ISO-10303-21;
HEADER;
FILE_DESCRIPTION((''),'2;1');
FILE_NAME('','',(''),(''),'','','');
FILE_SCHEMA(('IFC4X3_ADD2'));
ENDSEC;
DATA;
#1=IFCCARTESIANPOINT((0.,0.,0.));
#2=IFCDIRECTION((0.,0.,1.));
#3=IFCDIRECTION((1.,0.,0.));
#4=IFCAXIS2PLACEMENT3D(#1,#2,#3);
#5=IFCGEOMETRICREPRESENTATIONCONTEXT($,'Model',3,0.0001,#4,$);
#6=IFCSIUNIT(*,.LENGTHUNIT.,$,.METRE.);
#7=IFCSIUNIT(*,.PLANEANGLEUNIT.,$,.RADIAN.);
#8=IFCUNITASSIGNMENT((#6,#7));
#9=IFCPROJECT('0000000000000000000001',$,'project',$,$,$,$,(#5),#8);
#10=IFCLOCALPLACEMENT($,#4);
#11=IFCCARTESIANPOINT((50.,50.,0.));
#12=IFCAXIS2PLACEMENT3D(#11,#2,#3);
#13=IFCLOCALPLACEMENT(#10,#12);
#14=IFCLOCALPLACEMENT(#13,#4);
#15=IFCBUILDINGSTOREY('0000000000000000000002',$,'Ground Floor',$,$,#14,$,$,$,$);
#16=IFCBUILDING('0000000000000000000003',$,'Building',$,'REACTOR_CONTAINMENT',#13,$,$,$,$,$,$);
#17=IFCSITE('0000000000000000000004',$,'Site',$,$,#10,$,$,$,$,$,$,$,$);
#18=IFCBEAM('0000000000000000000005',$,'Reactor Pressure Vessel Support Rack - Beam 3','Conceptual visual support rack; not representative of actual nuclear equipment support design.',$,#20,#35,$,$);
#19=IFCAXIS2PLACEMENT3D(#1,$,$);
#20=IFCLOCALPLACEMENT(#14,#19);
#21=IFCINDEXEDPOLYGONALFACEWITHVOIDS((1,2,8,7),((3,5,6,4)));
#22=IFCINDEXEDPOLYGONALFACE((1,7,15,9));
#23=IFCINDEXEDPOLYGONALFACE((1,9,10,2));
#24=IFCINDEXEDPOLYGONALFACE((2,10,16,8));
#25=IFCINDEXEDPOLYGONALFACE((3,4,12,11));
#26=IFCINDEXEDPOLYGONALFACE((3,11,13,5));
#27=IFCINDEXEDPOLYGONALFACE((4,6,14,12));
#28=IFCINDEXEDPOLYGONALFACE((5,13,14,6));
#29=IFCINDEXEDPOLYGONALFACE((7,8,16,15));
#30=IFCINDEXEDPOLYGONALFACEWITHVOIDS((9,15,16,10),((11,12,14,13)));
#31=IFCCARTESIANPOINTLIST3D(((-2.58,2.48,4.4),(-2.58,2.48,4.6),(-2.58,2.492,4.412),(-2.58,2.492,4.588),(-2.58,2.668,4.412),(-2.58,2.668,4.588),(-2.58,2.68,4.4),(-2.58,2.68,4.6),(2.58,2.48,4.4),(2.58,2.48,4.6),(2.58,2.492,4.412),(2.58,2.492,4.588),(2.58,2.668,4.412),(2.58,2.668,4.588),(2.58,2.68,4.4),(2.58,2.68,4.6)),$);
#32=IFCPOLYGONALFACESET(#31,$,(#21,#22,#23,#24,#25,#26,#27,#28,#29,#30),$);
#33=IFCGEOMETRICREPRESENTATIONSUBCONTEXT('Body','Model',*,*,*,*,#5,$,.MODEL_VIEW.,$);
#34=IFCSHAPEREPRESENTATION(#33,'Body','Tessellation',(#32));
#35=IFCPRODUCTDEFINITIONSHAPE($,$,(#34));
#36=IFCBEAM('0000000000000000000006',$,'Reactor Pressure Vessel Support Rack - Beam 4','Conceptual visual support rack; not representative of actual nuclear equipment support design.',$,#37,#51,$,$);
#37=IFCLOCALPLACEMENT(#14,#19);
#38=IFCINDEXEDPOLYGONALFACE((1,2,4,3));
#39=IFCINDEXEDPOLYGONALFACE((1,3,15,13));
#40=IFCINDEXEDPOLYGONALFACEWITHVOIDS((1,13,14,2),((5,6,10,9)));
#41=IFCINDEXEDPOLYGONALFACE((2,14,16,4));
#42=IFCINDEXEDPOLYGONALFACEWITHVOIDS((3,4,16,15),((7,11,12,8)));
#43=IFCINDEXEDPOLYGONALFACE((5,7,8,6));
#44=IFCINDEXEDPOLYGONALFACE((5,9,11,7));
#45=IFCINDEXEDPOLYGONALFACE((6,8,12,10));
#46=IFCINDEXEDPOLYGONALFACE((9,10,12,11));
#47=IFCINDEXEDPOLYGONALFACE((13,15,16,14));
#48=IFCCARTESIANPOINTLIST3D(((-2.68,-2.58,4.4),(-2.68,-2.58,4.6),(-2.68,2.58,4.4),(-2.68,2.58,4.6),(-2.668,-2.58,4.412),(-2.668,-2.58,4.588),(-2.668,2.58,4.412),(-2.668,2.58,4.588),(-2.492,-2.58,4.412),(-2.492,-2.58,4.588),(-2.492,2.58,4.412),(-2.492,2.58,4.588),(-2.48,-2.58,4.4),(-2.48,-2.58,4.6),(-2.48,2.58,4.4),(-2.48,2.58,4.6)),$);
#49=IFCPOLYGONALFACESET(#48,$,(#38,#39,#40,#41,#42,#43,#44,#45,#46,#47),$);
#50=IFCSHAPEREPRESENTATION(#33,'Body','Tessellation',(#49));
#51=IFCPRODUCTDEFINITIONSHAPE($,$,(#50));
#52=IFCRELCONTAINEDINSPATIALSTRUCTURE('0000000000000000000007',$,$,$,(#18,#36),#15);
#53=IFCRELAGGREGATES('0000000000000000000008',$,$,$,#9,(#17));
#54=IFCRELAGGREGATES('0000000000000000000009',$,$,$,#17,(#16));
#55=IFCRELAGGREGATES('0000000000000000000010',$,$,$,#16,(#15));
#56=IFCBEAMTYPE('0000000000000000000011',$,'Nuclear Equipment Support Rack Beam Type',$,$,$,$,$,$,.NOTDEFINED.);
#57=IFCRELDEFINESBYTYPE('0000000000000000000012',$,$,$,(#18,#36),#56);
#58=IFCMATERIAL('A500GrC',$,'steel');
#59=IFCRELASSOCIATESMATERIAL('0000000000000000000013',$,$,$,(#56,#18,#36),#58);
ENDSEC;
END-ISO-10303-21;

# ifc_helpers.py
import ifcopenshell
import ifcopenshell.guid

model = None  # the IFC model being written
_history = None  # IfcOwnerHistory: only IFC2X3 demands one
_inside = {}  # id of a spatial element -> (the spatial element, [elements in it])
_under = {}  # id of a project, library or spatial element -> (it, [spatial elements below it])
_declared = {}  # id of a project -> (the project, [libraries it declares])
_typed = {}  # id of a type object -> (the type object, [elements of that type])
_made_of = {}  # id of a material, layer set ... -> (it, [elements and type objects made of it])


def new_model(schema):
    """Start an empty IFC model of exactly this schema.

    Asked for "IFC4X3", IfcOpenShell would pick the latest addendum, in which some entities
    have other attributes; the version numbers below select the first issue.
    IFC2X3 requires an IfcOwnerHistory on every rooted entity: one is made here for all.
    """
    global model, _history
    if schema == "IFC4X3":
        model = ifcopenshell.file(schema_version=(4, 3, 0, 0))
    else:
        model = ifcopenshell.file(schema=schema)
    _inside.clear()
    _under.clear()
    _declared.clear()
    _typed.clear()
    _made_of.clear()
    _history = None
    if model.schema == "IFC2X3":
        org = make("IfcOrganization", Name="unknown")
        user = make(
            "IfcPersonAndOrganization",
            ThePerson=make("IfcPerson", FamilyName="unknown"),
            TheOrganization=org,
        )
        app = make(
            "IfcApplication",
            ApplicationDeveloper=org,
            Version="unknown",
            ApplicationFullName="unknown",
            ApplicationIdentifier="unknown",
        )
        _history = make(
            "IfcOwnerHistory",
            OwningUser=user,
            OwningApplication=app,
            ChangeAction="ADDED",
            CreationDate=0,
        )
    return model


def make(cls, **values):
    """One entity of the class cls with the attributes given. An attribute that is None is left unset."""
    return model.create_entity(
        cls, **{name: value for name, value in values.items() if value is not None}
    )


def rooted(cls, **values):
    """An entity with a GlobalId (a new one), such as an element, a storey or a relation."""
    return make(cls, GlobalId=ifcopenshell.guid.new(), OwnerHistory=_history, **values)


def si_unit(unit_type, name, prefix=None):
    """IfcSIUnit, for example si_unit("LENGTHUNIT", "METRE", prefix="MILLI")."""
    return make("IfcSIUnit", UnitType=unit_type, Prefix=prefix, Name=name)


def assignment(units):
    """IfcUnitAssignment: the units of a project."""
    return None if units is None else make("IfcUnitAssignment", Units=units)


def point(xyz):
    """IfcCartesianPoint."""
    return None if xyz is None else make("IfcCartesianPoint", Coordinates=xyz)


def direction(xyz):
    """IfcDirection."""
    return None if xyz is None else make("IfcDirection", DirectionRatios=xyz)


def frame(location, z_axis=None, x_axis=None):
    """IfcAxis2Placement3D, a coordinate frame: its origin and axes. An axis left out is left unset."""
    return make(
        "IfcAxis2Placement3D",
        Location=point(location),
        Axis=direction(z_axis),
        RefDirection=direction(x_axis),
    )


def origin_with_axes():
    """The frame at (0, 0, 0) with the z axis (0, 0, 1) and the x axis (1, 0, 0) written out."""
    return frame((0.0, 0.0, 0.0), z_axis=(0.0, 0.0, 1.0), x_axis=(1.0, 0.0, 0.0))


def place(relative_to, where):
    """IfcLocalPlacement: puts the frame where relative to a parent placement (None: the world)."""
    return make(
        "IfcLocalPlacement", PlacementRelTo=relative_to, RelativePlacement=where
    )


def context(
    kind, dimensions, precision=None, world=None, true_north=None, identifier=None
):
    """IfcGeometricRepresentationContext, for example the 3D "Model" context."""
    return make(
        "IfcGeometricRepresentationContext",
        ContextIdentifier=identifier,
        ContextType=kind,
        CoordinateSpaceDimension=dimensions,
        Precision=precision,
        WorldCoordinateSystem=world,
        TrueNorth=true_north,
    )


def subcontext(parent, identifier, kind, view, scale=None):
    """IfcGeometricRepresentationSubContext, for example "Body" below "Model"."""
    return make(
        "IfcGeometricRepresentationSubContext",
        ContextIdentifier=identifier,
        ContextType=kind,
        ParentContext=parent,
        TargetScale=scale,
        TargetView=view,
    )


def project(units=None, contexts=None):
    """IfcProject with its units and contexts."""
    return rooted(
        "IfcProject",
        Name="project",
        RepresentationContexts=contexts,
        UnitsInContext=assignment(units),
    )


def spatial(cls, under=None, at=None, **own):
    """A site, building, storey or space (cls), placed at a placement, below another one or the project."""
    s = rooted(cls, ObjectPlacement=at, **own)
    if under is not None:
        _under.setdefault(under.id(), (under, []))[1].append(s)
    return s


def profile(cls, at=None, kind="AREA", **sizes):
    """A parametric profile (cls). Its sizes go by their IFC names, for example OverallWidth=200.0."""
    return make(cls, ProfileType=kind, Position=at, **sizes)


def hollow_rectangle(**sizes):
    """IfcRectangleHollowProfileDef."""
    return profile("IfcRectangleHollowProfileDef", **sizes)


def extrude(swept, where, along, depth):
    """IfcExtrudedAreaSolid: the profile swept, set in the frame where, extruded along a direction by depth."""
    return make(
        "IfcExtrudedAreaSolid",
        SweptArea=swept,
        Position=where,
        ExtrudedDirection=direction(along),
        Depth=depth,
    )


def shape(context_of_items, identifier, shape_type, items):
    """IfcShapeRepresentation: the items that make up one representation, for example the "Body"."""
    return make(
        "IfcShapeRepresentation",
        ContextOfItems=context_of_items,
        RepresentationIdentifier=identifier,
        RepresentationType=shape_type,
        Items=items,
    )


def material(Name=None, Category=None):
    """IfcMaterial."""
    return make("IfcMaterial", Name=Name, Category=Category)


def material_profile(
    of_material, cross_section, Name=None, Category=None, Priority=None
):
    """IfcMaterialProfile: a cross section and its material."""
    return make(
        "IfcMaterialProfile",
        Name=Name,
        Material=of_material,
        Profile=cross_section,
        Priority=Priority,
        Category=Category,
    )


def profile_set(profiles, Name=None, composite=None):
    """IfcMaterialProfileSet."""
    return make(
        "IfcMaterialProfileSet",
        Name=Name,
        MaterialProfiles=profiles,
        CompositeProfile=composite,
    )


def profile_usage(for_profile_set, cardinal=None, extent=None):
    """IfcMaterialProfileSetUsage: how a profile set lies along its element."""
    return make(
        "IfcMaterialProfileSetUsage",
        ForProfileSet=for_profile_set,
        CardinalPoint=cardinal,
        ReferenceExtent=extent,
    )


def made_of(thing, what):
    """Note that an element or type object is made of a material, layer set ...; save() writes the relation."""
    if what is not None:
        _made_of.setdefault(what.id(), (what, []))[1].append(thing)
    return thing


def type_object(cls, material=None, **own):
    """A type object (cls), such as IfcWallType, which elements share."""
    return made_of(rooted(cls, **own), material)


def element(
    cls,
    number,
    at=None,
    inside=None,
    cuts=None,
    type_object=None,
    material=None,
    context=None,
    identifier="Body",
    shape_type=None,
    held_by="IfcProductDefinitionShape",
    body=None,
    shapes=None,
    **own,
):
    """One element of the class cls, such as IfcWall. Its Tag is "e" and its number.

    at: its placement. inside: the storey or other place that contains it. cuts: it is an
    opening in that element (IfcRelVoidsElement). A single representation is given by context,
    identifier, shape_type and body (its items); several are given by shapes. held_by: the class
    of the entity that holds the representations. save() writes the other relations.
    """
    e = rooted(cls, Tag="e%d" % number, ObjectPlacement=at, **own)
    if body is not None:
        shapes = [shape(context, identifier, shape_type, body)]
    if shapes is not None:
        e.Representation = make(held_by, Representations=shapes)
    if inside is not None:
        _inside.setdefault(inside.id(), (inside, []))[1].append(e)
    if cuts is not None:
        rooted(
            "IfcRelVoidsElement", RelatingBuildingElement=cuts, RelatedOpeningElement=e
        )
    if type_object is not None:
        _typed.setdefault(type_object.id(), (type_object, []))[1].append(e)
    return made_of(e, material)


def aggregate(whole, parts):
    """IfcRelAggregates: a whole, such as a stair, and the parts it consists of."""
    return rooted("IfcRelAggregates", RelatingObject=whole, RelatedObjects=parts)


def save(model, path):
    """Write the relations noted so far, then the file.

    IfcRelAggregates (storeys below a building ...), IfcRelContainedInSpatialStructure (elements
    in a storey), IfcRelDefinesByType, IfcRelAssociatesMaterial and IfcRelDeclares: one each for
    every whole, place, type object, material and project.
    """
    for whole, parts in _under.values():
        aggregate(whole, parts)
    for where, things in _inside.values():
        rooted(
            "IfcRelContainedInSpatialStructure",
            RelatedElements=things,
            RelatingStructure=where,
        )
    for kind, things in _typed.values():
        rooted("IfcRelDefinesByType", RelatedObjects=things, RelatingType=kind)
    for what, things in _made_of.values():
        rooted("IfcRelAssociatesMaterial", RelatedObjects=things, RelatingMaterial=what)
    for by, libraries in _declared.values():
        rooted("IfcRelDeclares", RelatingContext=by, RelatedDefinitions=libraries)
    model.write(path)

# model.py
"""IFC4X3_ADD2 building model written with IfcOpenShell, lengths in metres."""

from ifc_helpers import new_model, si_unit, frame, origin_with_axes, place, context, subcontext, project, spatial, hollow_rectangle, extrude, material, material_profile, profile_set, profile_usage, type_object, element, save


model = new_model("IFC4X3_ADD2")

# Units and contexts
model_context = context("Model", 3, precision=0.0001, world=origin_with_axes())
body_context = subcontext(model_context, "Body", "Model", "MODEL_VIEW")
ifc_project = project(units=[si_unit("LENGTHUNIT", "METRE"), si_unit("PLANEANGLEUNIT", "RADIAN")], contexts=[model_context])

# Site, building, storey
site_placement = place(None, origin_with_axes())
site = spatial("IfcSite", under=ifc_project, at=site_placement, Name="Site")
building_placement = place(site_placement, frame((50.0, 50.0, 0.0), z_axis=(0.0, 0.0, 1.0), x_axis=(1.0, 0.0, 0.0)))
building = spatial("IfcBuilding", under=site, at=building_placement, Name="Building", ObjectType="REACTOR_CONTAINMENT")
storey_placement = place(building_placement, origin_with_axes())
storey = spatial("IfcBuildingStorey", under=building, at=storey_placement, Name="Ground Floor")

# Shared definitions
ifc_material = material(Name="A500GrC", Category="steel")
ifc_material_profile = material_profile(ifc_material, hollow_rectangle(XDim=0.2, YDim=0.2, WallThickness=0.012))
ifc_profile_set = profile_set([ifc_material_profile], Name="A500GrC steel Nuclear Equipment Support Rack HSS")

# Beams
beam_type = type_object("IfcBeamType", Name="Nuclear Equipment Support Rack Beam Type", PredefinedType="NOTDEFINED", material=ifc_profile_set)
ifc_profile_usage_1 = profile_usage(ifc_profile_set, cardinal=5)
beam_1_placement = place(None, frame((52.58, 52.58, 4.5), z_axis=(-1.0, 0.0, 0.0), x_axis=(0.0, -1.0, 0.0)))
element("IfcBeam", 1, at=beam_1_placement, inside=storey, type_object=beam_type, material=ifc_profile_usage_1, Name="Reactor Pressure Vessel Support Rack - Beam 3", Description="Conceptual visual support rack; not representative of actual nuclear equipment support design.", context=body_context, shape_type="SweptSolid", body=[
    extrude(hollow_rectangle(XDim=0.2, YDim=0.2, WallThickness=0.012), origin_with_axes(), (0.0, 0.0, 1.0), 5.16),
])
ifc_profile_usage_2 = profile_usage(ifc_profile_set, cardinal=5)
beam_2_placement = place(None, frame((47.42, 52.58, 4.5), z_axis=(0.0, -1.0, 0.0), x_axis=(1.0, 0.0, 0.0)))
element("IfcBeam", 2, at=beam_2_placement, inside=storey, type_object=beam_type, material=ifc_profile_usage_2, Name="Reactor Pressure Vessel Support Rack - Beam 4", Description="Conceptual visual support rack; not representative of actual nuclear equipment support design.", context=body_context, shape_type="SweptSolid", body=[
    extrude(hollow_rectangle(XDim=0.2, YDim=0.2, WallThickness=0.012), origin_with_axes(), (0.0, 0.0, 1.0), 5.16),
])

save(model, "model.ifc")
